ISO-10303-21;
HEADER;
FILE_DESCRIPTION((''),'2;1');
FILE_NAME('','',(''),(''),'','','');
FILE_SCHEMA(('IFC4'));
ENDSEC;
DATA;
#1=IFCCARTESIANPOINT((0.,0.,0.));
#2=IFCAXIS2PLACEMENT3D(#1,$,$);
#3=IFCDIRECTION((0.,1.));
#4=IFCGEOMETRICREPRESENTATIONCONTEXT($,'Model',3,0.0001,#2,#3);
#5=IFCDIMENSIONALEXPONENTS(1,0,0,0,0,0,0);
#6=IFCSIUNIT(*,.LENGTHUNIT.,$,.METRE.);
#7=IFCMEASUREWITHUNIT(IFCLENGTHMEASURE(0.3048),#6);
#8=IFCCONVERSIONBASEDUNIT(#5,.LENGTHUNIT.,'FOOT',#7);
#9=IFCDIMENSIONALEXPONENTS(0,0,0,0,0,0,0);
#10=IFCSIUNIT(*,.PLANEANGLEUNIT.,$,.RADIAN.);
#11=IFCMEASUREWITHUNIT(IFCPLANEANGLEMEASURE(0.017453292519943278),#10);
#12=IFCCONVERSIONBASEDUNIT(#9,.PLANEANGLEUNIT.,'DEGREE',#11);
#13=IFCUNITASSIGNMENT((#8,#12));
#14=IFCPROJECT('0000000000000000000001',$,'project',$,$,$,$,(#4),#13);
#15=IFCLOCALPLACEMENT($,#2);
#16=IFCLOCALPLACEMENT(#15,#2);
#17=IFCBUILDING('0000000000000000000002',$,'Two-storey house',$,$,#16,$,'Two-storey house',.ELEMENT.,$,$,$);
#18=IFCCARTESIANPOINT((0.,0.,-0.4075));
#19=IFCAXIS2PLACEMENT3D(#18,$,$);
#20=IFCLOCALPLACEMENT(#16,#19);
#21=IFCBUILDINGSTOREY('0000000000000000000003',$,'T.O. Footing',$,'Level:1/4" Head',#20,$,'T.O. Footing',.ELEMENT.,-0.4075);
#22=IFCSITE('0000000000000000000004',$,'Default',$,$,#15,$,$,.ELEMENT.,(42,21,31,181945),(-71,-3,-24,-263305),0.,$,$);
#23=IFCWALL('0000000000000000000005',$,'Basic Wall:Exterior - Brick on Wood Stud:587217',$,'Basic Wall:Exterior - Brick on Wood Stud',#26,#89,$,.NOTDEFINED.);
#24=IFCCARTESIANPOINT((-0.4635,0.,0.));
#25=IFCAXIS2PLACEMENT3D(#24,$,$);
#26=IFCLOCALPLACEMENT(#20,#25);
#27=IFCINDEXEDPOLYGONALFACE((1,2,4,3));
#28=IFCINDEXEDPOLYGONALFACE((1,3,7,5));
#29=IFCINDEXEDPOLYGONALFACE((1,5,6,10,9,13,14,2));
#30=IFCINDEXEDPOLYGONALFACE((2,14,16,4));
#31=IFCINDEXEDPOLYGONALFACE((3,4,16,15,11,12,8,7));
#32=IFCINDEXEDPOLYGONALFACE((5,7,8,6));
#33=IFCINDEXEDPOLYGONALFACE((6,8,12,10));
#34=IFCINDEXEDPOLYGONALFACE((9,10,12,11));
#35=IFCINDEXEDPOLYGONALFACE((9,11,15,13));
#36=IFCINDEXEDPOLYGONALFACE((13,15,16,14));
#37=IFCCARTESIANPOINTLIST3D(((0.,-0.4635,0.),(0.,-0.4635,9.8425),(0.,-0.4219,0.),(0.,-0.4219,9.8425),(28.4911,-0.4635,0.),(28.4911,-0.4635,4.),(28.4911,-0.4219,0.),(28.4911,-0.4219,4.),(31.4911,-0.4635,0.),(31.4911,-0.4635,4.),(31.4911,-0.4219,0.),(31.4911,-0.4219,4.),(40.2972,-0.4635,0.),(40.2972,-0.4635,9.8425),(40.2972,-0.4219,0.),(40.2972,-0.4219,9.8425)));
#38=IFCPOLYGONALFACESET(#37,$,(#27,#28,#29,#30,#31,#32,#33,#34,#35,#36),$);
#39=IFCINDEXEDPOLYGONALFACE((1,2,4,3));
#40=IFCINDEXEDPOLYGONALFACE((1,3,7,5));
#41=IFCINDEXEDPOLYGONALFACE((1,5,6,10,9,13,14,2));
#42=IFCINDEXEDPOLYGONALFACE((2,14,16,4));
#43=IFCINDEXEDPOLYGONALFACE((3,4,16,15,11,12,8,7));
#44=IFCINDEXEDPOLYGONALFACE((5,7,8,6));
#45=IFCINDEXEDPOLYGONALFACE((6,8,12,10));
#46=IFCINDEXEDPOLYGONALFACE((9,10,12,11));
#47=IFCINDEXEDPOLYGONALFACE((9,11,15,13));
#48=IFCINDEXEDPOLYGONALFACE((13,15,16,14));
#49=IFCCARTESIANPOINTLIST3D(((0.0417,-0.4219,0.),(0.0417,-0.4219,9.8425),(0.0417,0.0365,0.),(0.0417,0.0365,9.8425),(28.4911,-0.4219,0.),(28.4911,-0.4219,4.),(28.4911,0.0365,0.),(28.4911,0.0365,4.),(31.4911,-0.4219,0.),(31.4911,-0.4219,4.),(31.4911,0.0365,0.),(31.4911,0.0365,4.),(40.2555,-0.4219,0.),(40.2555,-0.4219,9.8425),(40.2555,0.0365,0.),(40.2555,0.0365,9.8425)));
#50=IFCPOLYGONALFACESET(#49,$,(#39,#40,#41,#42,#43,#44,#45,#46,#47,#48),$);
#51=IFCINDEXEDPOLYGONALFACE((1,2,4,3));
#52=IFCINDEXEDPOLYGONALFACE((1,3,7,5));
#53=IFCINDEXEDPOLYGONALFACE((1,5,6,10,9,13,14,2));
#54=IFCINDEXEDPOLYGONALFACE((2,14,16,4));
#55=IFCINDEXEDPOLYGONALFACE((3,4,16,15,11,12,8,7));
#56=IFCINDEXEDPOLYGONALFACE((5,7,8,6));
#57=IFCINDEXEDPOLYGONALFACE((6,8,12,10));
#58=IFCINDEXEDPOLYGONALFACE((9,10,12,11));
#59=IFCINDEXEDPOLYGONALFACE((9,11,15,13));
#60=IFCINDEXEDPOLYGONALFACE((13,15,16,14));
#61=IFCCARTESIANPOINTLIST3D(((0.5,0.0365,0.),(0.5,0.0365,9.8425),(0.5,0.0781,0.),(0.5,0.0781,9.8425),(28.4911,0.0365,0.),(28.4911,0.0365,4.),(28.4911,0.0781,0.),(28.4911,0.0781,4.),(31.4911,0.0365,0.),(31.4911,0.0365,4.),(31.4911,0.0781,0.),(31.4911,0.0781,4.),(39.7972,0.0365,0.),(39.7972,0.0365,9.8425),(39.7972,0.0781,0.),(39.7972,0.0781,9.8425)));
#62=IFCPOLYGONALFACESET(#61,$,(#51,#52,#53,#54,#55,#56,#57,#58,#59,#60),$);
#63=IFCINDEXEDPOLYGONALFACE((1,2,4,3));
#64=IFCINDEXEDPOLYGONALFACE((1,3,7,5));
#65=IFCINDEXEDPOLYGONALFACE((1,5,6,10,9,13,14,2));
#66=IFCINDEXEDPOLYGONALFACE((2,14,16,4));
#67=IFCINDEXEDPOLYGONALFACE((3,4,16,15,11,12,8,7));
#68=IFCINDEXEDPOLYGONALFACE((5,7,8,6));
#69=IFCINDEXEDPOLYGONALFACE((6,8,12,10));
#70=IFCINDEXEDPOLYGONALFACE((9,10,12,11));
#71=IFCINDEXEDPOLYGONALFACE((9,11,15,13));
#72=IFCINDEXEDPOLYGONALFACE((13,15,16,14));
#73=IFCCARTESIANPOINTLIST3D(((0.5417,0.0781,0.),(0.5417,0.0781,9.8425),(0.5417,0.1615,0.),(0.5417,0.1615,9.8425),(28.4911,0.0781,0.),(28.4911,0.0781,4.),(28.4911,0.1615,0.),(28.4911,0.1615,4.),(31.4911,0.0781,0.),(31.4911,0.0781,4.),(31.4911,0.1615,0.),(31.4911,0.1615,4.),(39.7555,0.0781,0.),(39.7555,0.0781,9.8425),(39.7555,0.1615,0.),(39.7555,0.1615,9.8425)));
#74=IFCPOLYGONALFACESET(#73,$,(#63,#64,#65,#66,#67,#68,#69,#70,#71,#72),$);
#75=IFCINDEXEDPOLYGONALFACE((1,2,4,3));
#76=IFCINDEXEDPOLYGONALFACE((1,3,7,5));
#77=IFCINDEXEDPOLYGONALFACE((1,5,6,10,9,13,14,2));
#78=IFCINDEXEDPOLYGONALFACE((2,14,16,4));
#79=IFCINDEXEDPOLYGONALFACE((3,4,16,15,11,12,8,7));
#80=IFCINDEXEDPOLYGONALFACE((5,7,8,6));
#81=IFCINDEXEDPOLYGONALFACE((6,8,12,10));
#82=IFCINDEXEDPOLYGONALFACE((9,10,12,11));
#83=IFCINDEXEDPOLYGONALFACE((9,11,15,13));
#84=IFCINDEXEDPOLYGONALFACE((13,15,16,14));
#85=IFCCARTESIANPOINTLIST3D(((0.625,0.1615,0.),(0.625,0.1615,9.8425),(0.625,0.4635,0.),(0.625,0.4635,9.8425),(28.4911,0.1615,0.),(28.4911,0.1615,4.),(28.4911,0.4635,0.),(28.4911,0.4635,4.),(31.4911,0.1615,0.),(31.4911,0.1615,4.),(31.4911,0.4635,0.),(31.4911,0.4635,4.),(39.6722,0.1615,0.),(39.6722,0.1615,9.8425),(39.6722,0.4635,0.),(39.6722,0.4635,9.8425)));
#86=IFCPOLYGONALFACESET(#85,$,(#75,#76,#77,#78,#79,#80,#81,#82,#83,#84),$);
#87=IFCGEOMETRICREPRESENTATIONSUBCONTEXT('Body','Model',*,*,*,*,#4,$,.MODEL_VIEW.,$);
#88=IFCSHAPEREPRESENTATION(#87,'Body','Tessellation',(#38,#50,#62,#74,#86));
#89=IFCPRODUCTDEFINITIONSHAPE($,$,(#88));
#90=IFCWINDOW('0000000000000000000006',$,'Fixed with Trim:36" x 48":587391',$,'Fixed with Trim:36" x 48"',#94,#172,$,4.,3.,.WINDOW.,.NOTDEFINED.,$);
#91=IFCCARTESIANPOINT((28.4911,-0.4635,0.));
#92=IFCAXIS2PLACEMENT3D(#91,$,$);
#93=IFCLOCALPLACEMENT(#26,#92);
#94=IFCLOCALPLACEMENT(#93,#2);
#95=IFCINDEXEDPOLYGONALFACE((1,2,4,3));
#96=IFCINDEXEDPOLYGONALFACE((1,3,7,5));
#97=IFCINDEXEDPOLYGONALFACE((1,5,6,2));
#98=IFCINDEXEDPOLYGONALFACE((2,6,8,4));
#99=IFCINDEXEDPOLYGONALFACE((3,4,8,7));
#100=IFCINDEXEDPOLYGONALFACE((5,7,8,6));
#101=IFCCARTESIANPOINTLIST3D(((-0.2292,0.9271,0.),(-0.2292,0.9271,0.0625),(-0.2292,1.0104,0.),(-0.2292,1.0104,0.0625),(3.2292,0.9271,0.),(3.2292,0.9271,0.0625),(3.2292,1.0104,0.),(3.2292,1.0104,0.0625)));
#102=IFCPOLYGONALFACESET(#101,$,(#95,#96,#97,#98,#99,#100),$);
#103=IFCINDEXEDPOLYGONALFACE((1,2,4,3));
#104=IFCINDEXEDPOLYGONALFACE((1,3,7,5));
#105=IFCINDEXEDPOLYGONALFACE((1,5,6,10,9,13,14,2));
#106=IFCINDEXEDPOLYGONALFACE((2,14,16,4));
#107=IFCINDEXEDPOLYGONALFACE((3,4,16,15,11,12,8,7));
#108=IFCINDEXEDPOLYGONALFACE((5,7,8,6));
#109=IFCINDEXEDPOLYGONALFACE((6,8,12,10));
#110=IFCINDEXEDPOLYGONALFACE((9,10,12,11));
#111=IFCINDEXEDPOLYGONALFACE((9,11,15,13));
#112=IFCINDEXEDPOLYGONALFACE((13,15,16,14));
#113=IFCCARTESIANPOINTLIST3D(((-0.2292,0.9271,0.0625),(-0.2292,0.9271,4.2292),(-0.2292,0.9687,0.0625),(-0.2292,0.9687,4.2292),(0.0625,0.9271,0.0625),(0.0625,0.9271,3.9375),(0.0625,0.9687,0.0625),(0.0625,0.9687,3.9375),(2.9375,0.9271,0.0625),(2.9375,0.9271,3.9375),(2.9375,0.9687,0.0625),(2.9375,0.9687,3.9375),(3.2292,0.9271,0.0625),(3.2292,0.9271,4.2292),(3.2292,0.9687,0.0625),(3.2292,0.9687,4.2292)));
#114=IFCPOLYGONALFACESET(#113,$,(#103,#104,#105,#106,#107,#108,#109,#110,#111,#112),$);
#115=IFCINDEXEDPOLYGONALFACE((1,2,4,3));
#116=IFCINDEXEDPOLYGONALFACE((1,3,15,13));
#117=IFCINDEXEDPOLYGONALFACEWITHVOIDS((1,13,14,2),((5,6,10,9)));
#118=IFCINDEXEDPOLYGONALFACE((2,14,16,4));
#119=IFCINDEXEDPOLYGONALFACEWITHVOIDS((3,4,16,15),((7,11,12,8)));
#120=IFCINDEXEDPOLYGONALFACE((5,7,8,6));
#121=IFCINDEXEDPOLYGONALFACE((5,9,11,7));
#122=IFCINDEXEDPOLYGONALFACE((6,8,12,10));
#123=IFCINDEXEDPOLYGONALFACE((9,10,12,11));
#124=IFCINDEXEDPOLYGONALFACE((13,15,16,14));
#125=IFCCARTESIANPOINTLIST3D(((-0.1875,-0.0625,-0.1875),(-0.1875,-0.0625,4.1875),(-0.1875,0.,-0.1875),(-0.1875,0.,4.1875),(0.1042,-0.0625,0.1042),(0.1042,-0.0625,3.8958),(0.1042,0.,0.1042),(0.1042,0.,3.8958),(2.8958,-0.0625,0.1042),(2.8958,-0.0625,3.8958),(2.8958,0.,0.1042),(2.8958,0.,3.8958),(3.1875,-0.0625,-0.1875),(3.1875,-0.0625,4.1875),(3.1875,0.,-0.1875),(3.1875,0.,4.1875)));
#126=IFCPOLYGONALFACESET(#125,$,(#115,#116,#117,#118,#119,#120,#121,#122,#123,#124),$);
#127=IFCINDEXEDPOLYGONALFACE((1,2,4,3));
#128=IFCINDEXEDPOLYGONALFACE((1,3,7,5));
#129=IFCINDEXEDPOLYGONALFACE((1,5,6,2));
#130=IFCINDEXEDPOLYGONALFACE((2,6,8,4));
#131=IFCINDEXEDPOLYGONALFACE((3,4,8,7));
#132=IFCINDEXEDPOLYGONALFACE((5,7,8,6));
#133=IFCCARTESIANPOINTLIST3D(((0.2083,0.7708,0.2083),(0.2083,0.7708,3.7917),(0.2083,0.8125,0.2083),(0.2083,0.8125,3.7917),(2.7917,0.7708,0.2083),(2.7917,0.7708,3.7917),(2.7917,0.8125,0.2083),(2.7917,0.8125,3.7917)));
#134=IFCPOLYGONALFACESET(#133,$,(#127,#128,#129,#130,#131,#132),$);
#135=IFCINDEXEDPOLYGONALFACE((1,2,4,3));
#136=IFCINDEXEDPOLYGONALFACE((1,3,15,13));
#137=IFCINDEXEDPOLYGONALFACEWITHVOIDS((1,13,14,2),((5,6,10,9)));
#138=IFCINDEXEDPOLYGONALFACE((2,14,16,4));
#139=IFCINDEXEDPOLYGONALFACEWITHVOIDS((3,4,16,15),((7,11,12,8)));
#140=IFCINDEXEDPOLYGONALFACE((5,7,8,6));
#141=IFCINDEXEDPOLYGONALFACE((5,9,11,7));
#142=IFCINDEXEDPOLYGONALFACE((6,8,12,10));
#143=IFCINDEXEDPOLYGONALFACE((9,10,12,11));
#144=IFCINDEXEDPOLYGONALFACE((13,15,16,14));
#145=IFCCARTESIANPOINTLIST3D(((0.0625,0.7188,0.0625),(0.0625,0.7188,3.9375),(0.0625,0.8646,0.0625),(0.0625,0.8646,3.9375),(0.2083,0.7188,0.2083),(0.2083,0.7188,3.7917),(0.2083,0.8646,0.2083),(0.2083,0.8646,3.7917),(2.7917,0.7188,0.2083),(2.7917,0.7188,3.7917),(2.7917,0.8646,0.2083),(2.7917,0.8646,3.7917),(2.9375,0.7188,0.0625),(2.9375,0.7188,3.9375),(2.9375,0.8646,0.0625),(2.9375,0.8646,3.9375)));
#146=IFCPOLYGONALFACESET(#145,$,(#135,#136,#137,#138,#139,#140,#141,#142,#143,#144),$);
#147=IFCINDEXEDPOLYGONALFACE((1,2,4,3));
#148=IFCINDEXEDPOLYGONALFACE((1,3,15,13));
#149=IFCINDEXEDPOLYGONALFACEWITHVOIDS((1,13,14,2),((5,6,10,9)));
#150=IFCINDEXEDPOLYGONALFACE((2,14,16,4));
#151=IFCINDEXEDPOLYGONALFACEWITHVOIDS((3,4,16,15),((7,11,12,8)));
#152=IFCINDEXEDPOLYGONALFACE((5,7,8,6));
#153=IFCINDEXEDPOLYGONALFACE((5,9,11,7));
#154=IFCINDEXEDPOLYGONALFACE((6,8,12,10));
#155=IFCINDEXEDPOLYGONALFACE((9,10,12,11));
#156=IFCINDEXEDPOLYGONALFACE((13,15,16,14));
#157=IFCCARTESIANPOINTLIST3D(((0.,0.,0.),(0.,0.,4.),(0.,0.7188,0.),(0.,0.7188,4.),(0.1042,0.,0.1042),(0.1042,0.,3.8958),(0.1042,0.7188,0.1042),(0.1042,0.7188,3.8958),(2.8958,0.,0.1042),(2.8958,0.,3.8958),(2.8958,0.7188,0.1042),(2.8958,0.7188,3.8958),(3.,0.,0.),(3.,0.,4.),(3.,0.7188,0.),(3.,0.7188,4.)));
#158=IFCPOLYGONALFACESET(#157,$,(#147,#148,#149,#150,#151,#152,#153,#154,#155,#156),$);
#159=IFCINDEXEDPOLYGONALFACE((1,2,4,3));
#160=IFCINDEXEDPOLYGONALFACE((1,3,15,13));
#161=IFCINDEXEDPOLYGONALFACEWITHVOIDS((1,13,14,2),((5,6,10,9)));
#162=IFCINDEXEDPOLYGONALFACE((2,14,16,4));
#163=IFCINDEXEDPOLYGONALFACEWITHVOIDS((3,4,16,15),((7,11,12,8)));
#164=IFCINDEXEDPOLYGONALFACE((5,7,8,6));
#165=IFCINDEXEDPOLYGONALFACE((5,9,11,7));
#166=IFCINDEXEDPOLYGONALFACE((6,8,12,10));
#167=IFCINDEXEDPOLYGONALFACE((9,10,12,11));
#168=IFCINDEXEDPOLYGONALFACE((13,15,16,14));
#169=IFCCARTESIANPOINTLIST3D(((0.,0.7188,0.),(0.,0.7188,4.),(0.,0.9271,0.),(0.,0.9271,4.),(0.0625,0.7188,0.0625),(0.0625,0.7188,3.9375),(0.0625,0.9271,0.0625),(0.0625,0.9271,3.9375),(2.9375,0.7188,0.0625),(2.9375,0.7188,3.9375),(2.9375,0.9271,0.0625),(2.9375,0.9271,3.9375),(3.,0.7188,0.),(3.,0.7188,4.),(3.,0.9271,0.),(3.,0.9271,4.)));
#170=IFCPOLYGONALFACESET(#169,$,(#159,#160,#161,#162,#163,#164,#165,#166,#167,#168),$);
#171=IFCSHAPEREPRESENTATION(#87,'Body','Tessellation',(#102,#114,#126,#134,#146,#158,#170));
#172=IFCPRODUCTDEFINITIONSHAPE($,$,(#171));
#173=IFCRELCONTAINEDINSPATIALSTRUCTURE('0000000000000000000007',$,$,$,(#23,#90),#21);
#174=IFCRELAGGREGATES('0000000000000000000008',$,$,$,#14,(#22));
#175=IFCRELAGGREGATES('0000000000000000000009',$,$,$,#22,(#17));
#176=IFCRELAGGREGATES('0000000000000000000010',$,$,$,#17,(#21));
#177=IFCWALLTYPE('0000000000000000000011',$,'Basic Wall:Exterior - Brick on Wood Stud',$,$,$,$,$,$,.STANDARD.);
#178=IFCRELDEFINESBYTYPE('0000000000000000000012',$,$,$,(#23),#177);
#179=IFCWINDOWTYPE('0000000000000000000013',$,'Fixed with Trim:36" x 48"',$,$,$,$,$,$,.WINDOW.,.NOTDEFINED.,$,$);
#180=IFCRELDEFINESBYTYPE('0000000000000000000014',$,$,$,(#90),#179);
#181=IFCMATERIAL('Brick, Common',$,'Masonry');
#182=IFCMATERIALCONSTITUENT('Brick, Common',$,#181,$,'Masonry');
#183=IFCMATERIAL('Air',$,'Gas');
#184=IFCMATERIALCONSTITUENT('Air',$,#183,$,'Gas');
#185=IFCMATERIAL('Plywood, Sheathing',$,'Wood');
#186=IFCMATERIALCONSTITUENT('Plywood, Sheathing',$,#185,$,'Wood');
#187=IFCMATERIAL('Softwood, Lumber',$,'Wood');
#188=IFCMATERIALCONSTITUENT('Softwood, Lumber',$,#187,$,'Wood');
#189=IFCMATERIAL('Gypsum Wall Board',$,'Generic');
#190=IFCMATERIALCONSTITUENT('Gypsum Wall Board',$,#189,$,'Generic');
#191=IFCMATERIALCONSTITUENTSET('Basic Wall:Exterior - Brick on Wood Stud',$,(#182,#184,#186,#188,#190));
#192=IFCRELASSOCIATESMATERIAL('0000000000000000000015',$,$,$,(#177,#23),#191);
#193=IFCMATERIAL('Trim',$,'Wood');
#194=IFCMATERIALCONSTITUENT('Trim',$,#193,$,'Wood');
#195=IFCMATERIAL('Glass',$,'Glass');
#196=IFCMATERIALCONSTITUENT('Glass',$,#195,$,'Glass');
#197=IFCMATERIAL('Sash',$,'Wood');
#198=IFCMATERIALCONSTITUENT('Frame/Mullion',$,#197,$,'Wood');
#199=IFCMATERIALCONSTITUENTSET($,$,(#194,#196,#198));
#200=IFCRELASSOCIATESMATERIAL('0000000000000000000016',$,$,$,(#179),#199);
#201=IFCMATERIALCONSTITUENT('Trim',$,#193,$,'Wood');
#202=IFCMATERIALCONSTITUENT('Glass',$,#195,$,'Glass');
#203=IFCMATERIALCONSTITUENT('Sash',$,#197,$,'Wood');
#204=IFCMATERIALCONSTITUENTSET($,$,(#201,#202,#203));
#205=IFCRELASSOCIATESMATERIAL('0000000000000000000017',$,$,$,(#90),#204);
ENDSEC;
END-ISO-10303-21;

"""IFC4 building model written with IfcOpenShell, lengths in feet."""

from ifc_helpers import new_model, entity, si_unit, converted_unit, direction, frame, origin, place, context, subcontext, project, spatial, indexed_curve, outline, extrude, source, transform, mapped, material, constituent, constituent_set, type_object, type_shapes, element, fill, save


model = new_model("IFC4")

# Units and contexts
model_context = context("Model", 3, precision=0.0001, world=origin(), true_north=direction((0.0, 1.0)))
body_context = subcontext(model_context, "Body", "Model", "MODEL_VIEW")
ifc_project = project(units=[converted_unit("LENGTHUNIT", "FOOT", entity("IfcLengthMeasure", 0.3048), si_unit("LENGTHUNIT", "METRE"), dimensions=[1, 0, 0, 0, 0, 0, 0]), converted_unit("PLANEANGLEUNIT", "DEGREE", entity("IfcPlaneAngleMeasure", 0.017453292519943278), si_unit("PLANEANGLEUNIT", "RADIAN"), dimensions=[0, 0, 0, 0, 0, 0, 0])], contexts=[model_context])

# Site, building, storey
site_placement = place(None, origin())
site = spatial("IfcSite", under=ifc_project, at=site_placement, Name="Default", CompositionType="ELEMENT", RefLatitude=(42, 21, 31, 181945), RefLongitude=(-71, -3, -24, -263305), RefElevation=0.0)
building_placement = place(site_placement, origin())
building = spatial("IfcBuilding", under=site, at=building_placement, Name="Two-storey house", LongName="Two-storey house", CompositionType="ELEMENT")
storey_placement = place(building_placement, frame((0.0, 0.0, -0.4075)))
storey = spatial("IfcBuildingStorey", under=building, at=storey_placement, Name="T.O. Footing", ObjectType="Level:1/4\" Head", LongName="T.O. Footing", CompositionType="ELEMENT", Elevation=-0.4075)

# Wall, opening, window
ifc_material_1 = material(Name="Brick, Common", Category="Masonry")
ifc_constituent_1 = constituent(ifc_material_1, Name="Brick, Common", Category="Masonry")
ifc_material_2 = material(Name="Air", Category="Gas")
ifc_constituent_2 = constituent(ifc_material_2, Name="Air", Category="Gas")
ifc_material_3 = material(Name="Plywood, Sheathing", Category="Wood")
ifc_constituent_3 = constituent(ifc_material_3, Name="Plywood, Sheathing", Category="Wood")
ifc_material_4 = material(Name="Softwood, Lumber", Category="Wood")
ifc_constituent_4 = constituent(ifc_material_4, Name="Softwood, Lumber", Category="Wood")
ifc_material_5 = material(Name="Gypsum Wall Board", Category="Generic")
ifc_constituent_5 = constituent(ifc_material_5, Name="Gypsum Wall Board", Category="Generic")
ifc_constituent_set_1 = constituent_set(constituents=[ifc_constituent_1, ifc_constituent_2, ifc_constituent_3, ifc_constituent_4, ifc_constituent_5], Name="Basic Wall:Exterior - Brick on Wood Stud")
wall_type = type_object("IfcWallType", Name="Basic Wall:Exterior - Brick on Wood Stud", PredefinedType="STANDARD", material=ifc_constituent_set_1)
wall_1_placement = place(storey_placement, frame((-0.4635, 0.0, 0.0)))
wall_1 = element("IfcWall", 1, at=wall_1_placement, inside=storey, type_object=wall_type, material=ifc_constituent_set_1, Name="Basic Wall:Exterior - Brick on Wood Stud:587217", ObjectType="Basic Wall:Exterior - Brick on Wood Stud", PredefinedType="NOTDEFINED", context=body_context, shape_type="SweptSolid", body=[
    extrude(outline(indexed_curve([(-3.4606, -25.0698), (6.3819, -25.0698), (6.3819, 15.2273), (-3.4606, 15.2273), (-3.4606, 6.4213), (0.5394, 6.4213), (0.5394, 3.4213), (-3.4606, 3.4213), (-3.4606, -25.0698)], self_intersect=False)), frame((25.0698, -0.4635, 3.4606), z_axis=(0.0, 1.0, 0.0), x_axis=(0.0, 0.0, 1.0)), (0.0, 0.0, 1.0), 0.0417),
    extrude(outline(indexed_curve([(-3.4606, -25.0282), (6.3819, -25.0282), (6.3819, 15.1857), (-3.4606, 15.1857), (-3.4606, 6.4213), (0.5394, 6.4213), (0.5394, 3.4213), (-3.4606, 3.4213), (-3.4606, -25.0282)], self_intersect=False)), frame((25.0698, -0.4219, 3.4606), z_axis=(0.0, 1.0, 0.0), x_axis=(0.0, 0.0, 1.0)), (0.0, 0.0, 1.0), 0.4583),
    extrude(outline(indexed_curve([(-3.4606, -24.5698), (6.3819, -24.5698), (6.3819, 14.7273), (-3.4606, 14.7273), (-3.4606, 6.4213), (0.5394, 6.4213), (0.5394, 3.4213), (-3.4606, 3.4213), (-3.4606, -24.5698)], self_intersect=False)), frame((25.0698, 0.0365, 3.4606), z_axis=(0.0, 1.0, 0.0), x_axis=(0.0, 0.0, 1.0)), (0.0, 0.0, 1.0), 0.0417),
    extrude(outline(indexed_curve([(-3.4606, -24.5282), (6.3819, -24.5282), (6.3819, 14.6857), (-3.4606, 14.6857), (-3.4606, 6.4213), (0.5394, 6.4213), (0.5394, 3.4213), (-3.4606, 3.4213), (-3.4606, -24.5282)], self_intersect=False)), frame((25.0698, 0.0781, 3.4606), z_axis=(0.0, 1.0, 0.0), x_axis=(0.0, 0.0, 1.0)), (0.0, 0.0, 1.0), 0.0833),
    extrude(outline(indexed_curve([(-3.4606, -24.4448), (6.3819, -24.4448), (6.3819, 14.6023), (-3.4606, 14.6023), (-3.4606, 6.4213), (0.5394, 6.4213), (0.5394, 3.4213), (-3.4606, 3.4213), (-3.4606, -24.4448)], self_intersect=False)), frame((25.0698, 0.1615, 3.4606), z_axis=(0.0, 1.0, 0.0), x_axis=(0.0, 0.0, 1.0)), (0.0, 0.0, 1.0), 0.3021),
])
opening_1_placement = place(wall_1_placement, frame((28.4911, -0.4635, 0.0)))
opening_1 = element("IfcOpeningElement", 2, at=opening_1_placement, cuts=wall_1, PredefinedType="OPENING", context=body_context, shape_type="SweptSolid", body=[
    extrude(outline(indexed_curve([(4.0, 3.0), (0.0, 3.0), (0.0, 0.0), (4.0, 0.0), (4.0, 3.0)], self_intersect=False)), frame((0.0, 0.0, 0.0), z_axis=(0.0, 1.0, 0.0), x_axis=(0.0, 0.0, 1.0)), (0.0, 0.0, 1.0), 0.9271),
])
ifc_material_6 = material(Name="Trim", Category="Wood")
ifc_constituent_6 = constituent(ifc_material_6, Name="Trim", Category="Wood")
ifc_material_7 = material(Name="Glass", Category="Glass")
ifc_constituent_7 = constituent(ifc_material_7, Name="Glass", Category="Glass")
ifc_material_8 = material(Name="Sash", Category="Wood")
ifc_constituent_8 = constituent(ifc_material_8, Name="Sash", Category="Wood")
ifc_constituent_set_2 = constituent_set(constituents=[ifc_constituent_6, ifc_constituent_7, ifc_constituent_8])
ifc_constituent_9 = constituent(ifc_material_6, Name="Trim", Category="Wood")
ifc_constituent_10 = constituent(ifc_material_7, Name="Glass", Category="Glass")
ifc_constituent_11 = constituent(ifc_material_8, Name="Frame/Mullion", Category="Wood")
ifc_constituent_set_3 = constituent_set(constituents=[ifc_constituent_9, ifc_constituent_10, ifc_constituent_11])
window_type = type_object("IfcWindowType", Name="Fixed with Trim:36\" x 48\"", PartitioningType="NOTDEFINED", PredefinedType="WINDOW", material=ifc_constituent_set_3)
shared_shape = source(origin(), body_context, "Body", "SweptSolid", [
    extrude(outline(indexed_curve([(-0.0417, -1.7292), (0.0417, -1.7292), (0.0417, 1.7292), (-0.0417, 1.7292), (-0.0417, -1.7292)], self_intersect=False)), frame((1.5, 0.9687, 0.0), z_axis=(0.0, 0.0, 1.0), x_axis=(0.0, -1.0, 0.0)), (0.0, 0.0, 1.0), 0.0625),
    extrude(outline(indexed_curve([(-1.8646, 1.4375), (2.0104, 1.4375), (2.0104, 1.7292), (-2.1562, 1.7292), (-2.1562, -1.7292), (2.0104, -1.7292), (2.0104, -1.4375), (-1.8646, -1.4375), (-1.8646, 1.4375)], self_intersect=False)), frame((1.5, 0.9271, 2.0729), z_axis=(0.0, 1.0, 0.0), x_axis=(0.0, 0.0, -1.0)), (0.0, 0.0, 1.0), 0.0417),
    extrude(outline(indexed_curve([(-2.1875, -1.6875), (2.1875, -1.6875), (2.1875, 1.6875), (-2.1875, 1.6875), (-2.1875, -1.6875)], self_intersect=False), holes=[indexed_curve([(-1.8958, -1.3958), (-1.8958, 1.3958), (1.8958, 1.3958), (1.8958, -1.3958), (-1.8958, -1.3958)], self_intersect=False)]), frame((1.5, -0.0625, 2.0), z_axis=(0.0, 1.0, 0.0), x_axis=(0.0, 0.0, -1.0)), (0.0, 0.0, 1.0), 0.0625),
    extrude(outline(indexed_curve([(-0.0208, -1.2917), (0.0208, -1.2917), (0.0208, 1.2917), (-0.0208, 1.2917), (-0.0208, -1.2917)], self_intersect=False)), frame((1.5, 0.7917, 0.2083), z_axis=(0.0, 0.0, 1.0), x_axis=(0.0, 1.0, 0.0)), (0.0, 0.0, 1.0), 3.5833),
    extrude(outline(indexed_curve([(-1.4375, -1.9375), (1.4375, -1.9375), (1.4375, 1.9375), (-1.4375, 1.9375), (-1.4375, -1.9375)], self_intersect=False), holes=[indexed_curve([(-1.2917, -1.7917), (-1.2917, 1.7917), (1.2917, 1.7917), (1.2917, -1.7917), (-1.2917, -1.7917)], self_intersect=False)]), frame((1.5, 0.7188, 2.0), z_axis=(0.0, 1.0, 0.0), x_axis=(1.0, 0.0, 0.0)), (0.0, 0.0, 1.0), 0.1458),
    extrude(outline(indexed_curve([(-1.5, -2.0), (1.5, -2.0), (1.5, 2.0), (-1.5, 2.0), (-1.5, -2.0)], self_intersect=False), holes=[indexed_curve([(-1.3958, -1.8958), (-1.3958, 1.8958), (1.3958, 1.8958), (1.3958, -1.8958), (-1.3958, -1.8958)], self_intersect=False)]), frame((1.5, 0.0, 2.0), z_axis=(0.0, 1.0, 0.0), x_axis=(1.0, 0.0, 0.0)), (0.0, 0.0, 1.0), 0.7188),
    extrude(outline(indexed_curve([(-2.0, -1.5), (2.0, -1.5), (2.0, 1.5), (-2.0, 1.5), (-2.0, -1.5)], self_intersect=False), holes=[indexed_curve([(-1.9375, -1.4375), (-1.9375, 1.4375), (1.9375, 1.4375), (1.9375, -1.4375), (-1.9375, -1.4375)], self_intersect=False)]), frame((1.5, 0.7188, 2.0), z_axis=(0.0, 1.0, 0.0), x_axis=(0.0, 0.0, -1.0)), (0.0, 0.0, 1.0), 0.2083),
])
type_shapes(window_type, [shared_shape])
window_1_placement = place(opening_1_placement, origin())
window_1 = element("IfcWindow", 3, at=window_1_placement, inside=storey, type_object=window_type, material=ifc_constituent_set_2, Name="Fixed with Trim:36\" x 48\":587391", ObjectType="Fixed with Trim:36\" x 48\"", OverallHeight=4.0, OverallWidth=3.0, PartitioningType="NOTDEFINED", PredefinedType="WINDOW", context=body_context, shape_type="MappedRepresentation", body=[
    mapped(shared_shape, transform((0.0, 0.0, 0.0), scale=1.0)),
])
fill(opening_1, window_1)

save(model, "model.ifc")
